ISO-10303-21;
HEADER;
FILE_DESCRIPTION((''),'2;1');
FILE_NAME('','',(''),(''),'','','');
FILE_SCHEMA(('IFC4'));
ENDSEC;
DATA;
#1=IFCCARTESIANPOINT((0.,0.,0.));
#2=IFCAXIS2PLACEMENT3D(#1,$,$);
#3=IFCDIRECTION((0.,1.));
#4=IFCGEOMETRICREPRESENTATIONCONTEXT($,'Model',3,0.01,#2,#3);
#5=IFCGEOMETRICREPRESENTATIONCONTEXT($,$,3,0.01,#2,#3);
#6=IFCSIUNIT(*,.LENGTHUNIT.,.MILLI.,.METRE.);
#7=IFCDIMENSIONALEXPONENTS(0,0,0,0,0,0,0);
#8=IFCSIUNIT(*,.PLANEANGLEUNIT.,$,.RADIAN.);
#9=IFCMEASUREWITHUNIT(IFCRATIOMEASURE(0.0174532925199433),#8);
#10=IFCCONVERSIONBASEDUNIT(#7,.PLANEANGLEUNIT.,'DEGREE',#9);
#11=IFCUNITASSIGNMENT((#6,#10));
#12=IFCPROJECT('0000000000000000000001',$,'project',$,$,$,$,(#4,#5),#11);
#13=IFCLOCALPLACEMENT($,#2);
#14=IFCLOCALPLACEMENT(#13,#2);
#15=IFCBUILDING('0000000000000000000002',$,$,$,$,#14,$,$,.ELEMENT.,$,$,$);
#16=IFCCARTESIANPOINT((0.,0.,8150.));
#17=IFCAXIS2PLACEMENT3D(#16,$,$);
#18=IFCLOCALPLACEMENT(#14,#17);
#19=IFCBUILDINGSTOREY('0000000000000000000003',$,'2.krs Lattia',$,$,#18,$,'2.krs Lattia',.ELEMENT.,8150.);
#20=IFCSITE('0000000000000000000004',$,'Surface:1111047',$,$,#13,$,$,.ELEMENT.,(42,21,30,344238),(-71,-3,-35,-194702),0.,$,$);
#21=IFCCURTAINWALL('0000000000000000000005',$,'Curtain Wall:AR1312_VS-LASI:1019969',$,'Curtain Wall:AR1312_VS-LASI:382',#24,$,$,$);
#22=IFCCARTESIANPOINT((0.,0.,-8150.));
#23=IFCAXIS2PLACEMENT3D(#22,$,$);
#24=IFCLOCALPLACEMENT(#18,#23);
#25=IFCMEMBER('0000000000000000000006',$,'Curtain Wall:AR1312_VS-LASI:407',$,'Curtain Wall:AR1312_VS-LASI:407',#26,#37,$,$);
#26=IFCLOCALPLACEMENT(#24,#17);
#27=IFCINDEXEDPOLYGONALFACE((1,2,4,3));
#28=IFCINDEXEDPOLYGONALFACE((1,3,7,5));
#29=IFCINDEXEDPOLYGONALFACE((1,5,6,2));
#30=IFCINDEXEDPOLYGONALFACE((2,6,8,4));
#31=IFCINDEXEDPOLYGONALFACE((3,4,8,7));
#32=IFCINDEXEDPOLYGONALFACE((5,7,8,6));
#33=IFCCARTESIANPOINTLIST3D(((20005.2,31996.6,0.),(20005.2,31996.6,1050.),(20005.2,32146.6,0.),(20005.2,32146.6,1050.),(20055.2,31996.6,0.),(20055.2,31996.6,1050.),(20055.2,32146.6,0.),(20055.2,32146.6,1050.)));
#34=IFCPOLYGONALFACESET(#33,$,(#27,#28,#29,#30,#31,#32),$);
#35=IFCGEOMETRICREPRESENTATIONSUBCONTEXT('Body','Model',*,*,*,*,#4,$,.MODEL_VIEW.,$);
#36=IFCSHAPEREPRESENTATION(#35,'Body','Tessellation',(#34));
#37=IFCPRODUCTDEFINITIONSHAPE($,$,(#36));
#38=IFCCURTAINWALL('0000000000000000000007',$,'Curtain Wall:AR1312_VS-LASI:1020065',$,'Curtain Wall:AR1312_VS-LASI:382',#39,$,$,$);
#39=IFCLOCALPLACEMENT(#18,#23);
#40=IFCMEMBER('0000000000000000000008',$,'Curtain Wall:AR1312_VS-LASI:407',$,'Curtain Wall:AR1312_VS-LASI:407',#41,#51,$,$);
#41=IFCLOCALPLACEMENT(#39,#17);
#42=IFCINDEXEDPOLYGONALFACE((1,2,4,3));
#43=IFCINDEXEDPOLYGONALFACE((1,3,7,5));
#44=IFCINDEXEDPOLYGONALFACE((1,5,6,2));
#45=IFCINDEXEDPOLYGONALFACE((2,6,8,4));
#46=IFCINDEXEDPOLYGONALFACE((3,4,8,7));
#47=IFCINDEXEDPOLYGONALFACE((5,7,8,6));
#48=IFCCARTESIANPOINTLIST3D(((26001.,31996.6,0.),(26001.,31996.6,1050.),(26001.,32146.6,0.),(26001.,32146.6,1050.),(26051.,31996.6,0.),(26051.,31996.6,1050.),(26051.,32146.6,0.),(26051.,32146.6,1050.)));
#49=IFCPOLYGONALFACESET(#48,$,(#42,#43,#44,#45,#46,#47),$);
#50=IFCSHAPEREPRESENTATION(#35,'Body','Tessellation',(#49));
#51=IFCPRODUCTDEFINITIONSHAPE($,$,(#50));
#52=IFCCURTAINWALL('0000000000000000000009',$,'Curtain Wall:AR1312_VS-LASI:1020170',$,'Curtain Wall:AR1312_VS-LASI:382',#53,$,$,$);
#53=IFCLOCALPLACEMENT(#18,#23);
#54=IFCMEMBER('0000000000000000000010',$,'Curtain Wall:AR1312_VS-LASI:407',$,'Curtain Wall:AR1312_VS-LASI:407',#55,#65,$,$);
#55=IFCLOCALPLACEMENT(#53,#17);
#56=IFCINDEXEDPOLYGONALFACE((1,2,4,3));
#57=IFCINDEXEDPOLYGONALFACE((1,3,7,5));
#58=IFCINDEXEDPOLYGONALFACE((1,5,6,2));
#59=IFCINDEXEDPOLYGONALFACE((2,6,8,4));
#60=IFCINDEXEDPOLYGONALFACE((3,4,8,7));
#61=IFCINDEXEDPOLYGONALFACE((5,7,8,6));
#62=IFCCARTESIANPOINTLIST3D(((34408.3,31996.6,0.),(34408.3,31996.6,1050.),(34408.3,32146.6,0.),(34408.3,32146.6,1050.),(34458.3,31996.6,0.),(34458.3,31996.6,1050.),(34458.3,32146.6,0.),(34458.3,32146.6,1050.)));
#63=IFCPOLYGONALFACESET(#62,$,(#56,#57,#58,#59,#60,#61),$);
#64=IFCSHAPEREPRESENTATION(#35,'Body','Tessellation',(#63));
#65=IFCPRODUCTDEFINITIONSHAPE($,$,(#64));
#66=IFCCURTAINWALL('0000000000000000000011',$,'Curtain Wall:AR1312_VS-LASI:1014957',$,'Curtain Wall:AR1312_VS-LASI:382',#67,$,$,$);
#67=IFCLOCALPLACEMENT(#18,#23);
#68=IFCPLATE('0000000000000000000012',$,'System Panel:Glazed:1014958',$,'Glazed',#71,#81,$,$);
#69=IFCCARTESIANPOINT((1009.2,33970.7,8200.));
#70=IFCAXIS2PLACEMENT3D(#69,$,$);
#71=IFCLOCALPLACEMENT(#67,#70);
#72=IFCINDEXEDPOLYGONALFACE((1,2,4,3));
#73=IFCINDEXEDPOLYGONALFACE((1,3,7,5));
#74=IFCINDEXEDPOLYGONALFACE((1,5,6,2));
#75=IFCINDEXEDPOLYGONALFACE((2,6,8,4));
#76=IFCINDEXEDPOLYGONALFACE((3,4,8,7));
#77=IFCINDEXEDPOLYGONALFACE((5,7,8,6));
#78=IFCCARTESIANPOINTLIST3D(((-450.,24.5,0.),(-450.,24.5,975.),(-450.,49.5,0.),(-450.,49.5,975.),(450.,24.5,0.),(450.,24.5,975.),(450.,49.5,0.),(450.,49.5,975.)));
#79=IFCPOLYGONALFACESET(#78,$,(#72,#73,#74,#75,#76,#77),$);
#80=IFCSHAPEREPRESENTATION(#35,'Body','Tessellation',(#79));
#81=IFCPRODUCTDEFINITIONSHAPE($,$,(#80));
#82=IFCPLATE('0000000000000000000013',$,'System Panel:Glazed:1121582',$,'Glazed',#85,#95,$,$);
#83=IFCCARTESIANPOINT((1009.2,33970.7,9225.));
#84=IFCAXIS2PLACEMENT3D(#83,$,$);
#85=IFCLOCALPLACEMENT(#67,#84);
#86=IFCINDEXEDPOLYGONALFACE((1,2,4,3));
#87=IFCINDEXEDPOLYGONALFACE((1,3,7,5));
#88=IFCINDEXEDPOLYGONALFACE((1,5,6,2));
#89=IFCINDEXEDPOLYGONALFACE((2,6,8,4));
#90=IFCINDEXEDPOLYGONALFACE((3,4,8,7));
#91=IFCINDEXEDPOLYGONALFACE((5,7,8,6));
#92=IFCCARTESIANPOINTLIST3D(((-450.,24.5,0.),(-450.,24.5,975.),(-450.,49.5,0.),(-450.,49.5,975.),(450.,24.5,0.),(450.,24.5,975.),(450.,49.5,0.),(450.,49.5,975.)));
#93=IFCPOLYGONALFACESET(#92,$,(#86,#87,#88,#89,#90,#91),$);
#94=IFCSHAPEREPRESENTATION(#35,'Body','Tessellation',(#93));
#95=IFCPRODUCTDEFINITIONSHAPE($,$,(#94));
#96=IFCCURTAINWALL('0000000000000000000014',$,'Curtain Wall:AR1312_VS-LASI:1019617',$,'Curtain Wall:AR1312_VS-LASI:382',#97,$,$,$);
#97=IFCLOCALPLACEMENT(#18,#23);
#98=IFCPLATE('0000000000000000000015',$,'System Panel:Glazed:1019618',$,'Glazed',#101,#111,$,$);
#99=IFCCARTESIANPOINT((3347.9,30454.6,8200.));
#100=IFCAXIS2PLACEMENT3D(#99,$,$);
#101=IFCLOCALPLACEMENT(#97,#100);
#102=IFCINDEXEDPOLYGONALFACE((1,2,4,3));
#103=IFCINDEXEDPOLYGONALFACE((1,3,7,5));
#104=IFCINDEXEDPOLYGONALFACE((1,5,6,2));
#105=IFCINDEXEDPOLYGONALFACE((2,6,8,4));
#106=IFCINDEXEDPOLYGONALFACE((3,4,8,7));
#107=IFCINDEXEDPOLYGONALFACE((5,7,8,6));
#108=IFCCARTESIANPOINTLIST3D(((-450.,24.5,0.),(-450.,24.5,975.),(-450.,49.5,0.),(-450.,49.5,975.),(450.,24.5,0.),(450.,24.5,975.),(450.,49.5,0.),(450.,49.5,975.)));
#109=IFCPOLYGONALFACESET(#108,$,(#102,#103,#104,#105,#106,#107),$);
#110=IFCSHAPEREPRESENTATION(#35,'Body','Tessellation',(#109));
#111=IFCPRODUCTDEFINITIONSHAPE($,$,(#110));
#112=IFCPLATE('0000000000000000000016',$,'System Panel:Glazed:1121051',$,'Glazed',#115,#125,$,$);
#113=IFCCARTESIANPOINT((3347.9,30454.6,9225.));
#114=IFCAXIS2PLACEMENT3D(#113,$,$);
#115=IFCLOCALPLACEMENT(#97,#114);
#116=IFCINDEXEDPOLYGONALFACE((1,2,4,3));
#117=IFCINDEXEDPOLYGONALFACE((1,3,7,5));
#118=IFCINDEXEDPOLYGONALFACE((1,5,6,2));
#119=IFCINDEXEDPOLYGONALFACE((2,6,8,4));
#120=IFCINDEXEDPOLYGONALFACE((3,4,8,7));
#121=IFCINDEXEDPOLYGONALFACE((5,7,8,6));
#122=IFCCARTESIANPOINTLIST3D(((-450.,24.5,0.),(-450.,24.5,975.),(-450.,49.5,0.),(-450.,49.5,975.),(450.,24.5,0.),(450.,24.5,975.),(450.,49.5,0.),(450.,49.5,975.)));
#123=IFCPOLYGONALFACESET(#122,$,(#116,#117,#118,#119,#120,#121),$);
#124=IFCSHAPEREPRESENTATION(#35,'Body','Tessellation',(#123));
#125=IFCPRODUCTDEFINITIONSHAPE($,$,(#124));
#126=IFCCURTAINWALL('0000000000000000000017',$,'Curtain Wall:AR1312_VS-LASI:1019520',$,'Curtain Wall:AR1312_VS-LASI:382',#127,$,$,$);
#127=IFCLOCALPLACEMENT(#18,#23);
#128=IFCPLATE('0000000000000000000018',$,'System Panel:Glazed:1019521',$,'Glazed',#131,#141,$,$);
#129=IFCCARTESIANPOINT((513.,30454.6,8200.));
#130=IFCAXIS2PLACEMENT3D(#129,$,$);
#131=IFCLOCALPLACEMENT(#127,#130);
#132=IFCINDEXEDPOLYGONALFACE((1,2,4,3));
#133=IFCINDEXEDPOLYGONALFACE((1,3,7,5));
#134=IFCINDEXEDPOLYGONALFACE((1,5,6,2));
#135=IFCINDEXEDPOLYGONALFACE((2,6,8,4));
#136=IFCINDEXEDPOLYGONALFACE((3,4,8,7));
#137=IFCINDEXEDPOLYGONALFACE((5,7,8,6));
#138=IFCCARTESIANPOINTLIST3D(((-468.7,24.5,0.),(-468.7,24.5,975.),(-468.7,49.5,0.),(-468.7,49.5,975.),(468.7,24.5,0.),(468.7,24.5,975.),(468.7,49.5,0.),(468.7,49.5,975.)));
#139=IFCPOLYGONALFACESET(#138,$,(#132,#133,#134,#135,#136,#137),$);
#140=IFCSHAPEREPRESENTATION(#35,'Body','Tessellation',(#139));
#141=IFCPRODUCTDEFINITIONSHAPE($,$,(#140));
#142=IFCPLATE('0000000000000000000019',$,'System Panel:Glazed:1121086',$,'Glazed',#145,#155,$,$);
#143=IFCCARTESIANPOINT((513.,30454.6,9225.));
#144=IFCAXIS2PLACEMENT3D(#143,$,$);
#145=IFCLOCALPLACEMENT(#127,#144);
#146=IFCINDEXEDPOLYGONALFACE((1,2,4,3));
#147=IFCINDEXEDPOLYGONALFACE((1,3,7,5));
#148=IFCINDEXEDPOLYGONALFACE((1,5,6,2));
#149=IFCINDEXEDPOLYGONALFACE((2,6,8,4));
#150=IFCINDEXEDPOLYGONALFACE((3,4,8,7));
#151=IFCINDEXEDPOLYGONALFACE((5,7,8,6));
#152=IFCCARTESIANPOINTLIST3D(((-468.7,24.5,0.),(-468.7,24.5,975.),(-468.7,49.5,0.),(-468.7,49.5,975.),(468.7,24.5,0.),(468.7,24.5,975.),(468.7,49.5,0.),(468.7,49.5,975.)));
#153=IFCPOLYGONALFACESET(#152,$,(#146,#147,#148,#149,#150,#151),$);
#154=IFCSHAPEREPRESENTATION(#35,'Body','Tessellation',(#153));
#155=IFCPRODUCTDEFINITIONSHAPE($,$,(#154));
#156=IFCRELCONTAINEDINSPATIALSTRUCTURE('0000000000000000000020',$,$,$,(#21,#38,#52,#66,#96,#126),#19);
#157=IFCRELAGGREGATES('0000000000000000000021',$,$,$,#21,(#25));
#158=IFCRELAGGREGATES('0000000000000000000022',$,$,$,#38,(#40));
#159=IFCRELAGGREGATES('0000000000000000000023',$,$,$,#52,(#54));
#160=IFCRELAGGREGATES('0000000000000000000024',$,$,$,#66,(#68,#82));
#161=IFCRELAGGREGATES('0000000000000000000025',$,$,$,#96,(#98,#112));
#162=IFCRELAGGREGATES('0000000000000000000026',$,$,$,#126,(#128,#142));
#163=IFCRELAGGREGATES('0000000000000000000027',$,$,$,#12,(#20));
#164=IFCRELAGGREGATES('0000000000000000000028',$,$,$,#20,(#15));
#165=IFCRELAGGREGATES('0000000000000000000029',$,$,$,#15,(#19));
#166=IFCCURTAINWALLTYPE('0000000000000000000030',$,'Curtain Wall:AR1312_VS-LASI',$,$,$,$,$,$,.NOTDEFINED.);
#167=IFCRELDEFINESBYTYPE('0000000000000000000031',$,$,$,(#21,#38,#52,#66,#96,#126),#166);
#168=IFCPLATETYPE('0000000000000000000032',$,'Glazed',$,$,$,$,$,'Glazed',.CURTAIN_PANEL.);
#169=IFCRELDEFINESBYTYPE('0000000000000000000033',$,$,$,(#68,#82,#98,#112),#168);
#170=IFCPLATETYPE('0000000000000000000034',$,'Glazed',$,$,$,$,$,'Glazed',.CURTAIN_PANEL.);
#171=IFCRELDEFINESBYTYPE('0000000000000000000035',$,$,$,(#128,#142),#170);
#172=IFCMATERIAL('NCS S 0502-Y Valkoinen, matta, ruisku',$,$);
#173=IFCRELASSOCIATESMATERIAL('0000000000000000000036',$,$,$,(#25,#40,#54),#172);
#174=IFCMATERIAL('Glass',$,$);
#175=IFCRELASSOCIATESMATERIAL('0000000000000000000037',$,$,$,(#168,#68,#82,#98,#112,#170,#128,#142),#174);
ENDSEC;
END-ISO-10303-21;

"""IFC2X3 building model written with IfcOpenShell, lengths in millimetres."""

from ifc_helpers import new_model, entity, si_unit, converted_unit, direction, frame, frame_2d, origin, origin_2d_with_axis, place, context, subcontext, project, spatial, rectangle, extrude, source, transform, mapped, material, type_object, type_shapes, element, aggregate, save


model = new_model("IFC2X3")

# Units and contexts
model_context = context("Model", 3, precision=0.01, world=origin(), true_north=direction((0.0, 1.0)))
context_of_model = context(None, 3, precision=0.01, world=origin(), true_north=direction((0.0, 1.0)))
body_context = subcontext(model_context, "Body", "Model", "MODEL_VIEW")
ifc_project = project(units=[si_unit("LENGTHUNIT", "METRE", prefix="MILLI"), converted_unit("PLANEANGLEUNIT", "DEGREE", entity("IfcRatioMeasure", 0.0174532925199433), si_unit("PLANEANGLEUNIT", "RADIAN"), dimensions=[0, 0, 0, 0, 0, 0, 0])], contexts=[model_context, context_of_model])

# Site, building, storey
site_placement = place(None, origin())
site = spatial("IfcSite", under=ifc_project, at=site_placement, Name="Surface:1111047", CompositionType="ELEMENT", RefLatitude=(42, 21, 30, 344238), RefLongitude=(-71, -3, -35, -194702), RefElevation=0.0)
building_placement = place(site_placement, origin())
building = spatial("IfcBuilding", under=site, at=building_placement, CompositionType="ELEMENT")
storey_placement = place(building_placement, frame((0.0, 0.0, 8150.0)))
storey = spatial("IfcBuildingStorey", under=building, at=storey_placement, Name="2.krs Lattia", LongName="2.krs Lattia", CompositionType="ELEMENT", Elevation=8150.0)

# Curtain walls, members
curtain_wall_type = type_object("IfcCurtainWallType", Name="Curtain Wall:AR1312_VS-LASI", PredefinedType="NOTDEFINED")
ifc_material_1 = material(Name="NCS S 0502-Y Valkoinen, matta, ruisku")
curtain_wall_1_placement = place(storey_placement, frame((0.0, 0.0, -8150.0)))
curtain_wall_1 = element("IfcCurtainWall", 1, at=curtain_wall_1_placement, inside=storey, type_object=curtain_wall_type, Name="Curtain Wall:AR1312_VS-LASI:1019969", ObjectType="Curtain Wall:AR1312_VS-LASI:382")
member_1_placement = place(curtain_wall_1_placement, frame((0.0, 0.0, 8150.0)))
member_1 = element("IfcMember", 2, at=member_1_placement, material=ifc_material_1, Name="Curtain Wall:AR1312_VS-LASI:407", ObjectType="Curtain Wall:AR1312_VS-LASI:407", context=body_context, shape_type="SweptSolid", body=[
    extrude(rectangle(XDim=50.0, YDim=150.0, at=frame_2d((0.0, 0.0), x_axis=(1.0, 0.0))), frame((20030.2, 32071.6, 0.0), z_axis=(0.0, 0.0, 1.0), x_axis=(-1.0, 0.0, 0.0)), (0.0, 0.0, 1.0), 1050.0),
])
aggregate(curtain_wall_1, [member_1])
curtain_wall_2_placement = place(storey_placement, frame((0.0, 0.0, -8150.0)))
curtain_wall_2 = element("IfcCurtainWall", 3, at=curtain_wall_2_placement, inside=storey, type_object=curtain_wall_type, Name="Curtain Wall:AR1312_VS-LASI:1020065", ObjectType="Curtain Wall:AR1312_VS-LASI:382")
member_2_placement = place(curtain_wall_2_placement, frame((0.0, 0.0, 8150.0)))
member_2 = element("IfcMember", 4, at=member_2_placement, material=ifc_material_1, Name="Curtain Wall:AR1312_VS-LASI:407", ObjectType="Curtain Wall:AR1312_VS-LASI:407", context=body_context, shape_type="SweptSolid", body=[
    extrude(rectangle(XDim=50.0, YDim=150.0, at=frame_2d((0.0, 0.0), x_axis=(1.0, 0.0))), frame((26026.0, 32071.6, 0.0), z_axis=(0.0, 0.0, 1.0), x_axis=(-1.0, 0.0, 0.0)), (0.0, 0.0, 1.0), 1050.0),
])
aggregate(curtain_wall_2, [member_2])
curtain_wall_3_placement = place(storey_placement, frame((0.0, 0.0, -8150.0)))
curtain_wall_3 = element("IfcCurtainWall", 5, at=curtain_wall_3_placement, inside=storey, type_object=curtain_wall_type, Name="Curtain Wall:AR1312_VS-LASI:1020170", ObjectType="Curtain Wall:AR1312_VS-LASI:382")
member_3_placement = place(curtain_wall_3_placement, frame((0.0, 0.0, 8150.0)))
member_3 = element("IfcMember", 6, at=member_3_placement, material=ifc_material_1, Name="Curtain Wall:AR1312_VS-LASI:407", ObjectType="Curtain Wall:AR1312_VS-LASI:407", context=body_context, shape_type="SweptSolid", body=[
    extrude(rectangle(XDim=50.0, YDim=150.0, at=frame_2d((0.0, 0.0), x_axis=(1.0, 0.0))), frame((34433.3, 32071.6, 0.0), z_axis=(0.0, 0.0, 1.0), x_axis=(-1.0, 0.0, 0.0)), (0.0, 0.0, 1.0), 1050.0),
])
aggregate(curtain_wall_3, [member_3])

# Curtain walls, plates
curtain_wall_4_placement = place(storey_placement, frame((0.0, 0.0, -8150.0)))
curtain_wall_4 = element("IfcCurtainWall", 7, at=curtain_wall_4_placement, inside=storey, type_object=curtain_wall_type, Name="Curtain Wall:AR1312_VS-LASI:1014957", ObjectType="Curtain Wall:AR1312_VS-LASI:382")
ifc_material_2 = material(Name="Glass")
plate_type_1 = type_object("IfcPlateType", Name="Glazed", ElementType="Glazed", PredefinedType="CURTAIN_PANEL", material=ifc_material_2)
shared_shape_1 = source(origin(), body_context, "Body", "SweptSolid", [
    extrude(rectangle(XDim=25.0, YDim=900.0, at=origin_2d_with_axis()), frame((0.0, 37.0, 0.0), z_axis=(0.0, 0.0, 1.0), x_axis=(0.0, 1.0, 0.0)), (0.0, 0.0, 1.0), 975.0),
])
type_shapes(plate_type_1, [shared_shape_1])
plate_1_placement = place(curtain_wall_4_placement, frame((1009.2, 33970.7, 8200.0)))
plate_1 = element("IfcPlate", 8, at=plate_1_placement, type_object=plate_type_1, material=ifc_material_2, Name="System Panel:Glazed:1014958", ObjectType="Glazed", context=body_context, shape_type="MappedRepresentation", body=[
    mapped(shared_shape_1, transform((0.0, 0.0, 0.0), scale=1.0)),
])
plate_2_placement = place(curtain_wall_4_placement, frame((1009.2, 33970.7, 9225.0)))
plate_2 = element("IfcPlate", 9, at=plate_2_placement, type_object=plate_type_1, material=ifc_material_2, Name="System Panel:Glazed:1121582", ObjectType="Glazed", context=body_context, shape_type="MappedRepresentation", body=[
    mapped(shared_shape_1, transform((0.0, 0.0, 0.0), scale=1.0)),
])
aggregate(curtain_wall_4, [plate_1, plate_2])
curtain_wall_5_placement = place(storey_placement, frame((0.0, 0.0, -8150.0)))
curtain_wall_5 = element("IfcCurtainWall", 10, at=curtain_wall_5_placement, inside=storey, type_object=curtain_wall_type, Name="Curtain Wall:AR1312_VS-LASI:1019617", ObjectType="Curtain Wall:AR1312_VS-LASI:382")
plate_3_placement = place(curtain_wall_5_placement, frame((3347.9, 30454.6, 8200.0)))
plate_3 = element("IfcPlate", 11, at=plate_3_placement, type_object=plate_type_1, material=ifc_material_2, Name="System Panel:Glazed:1019618", ObjectType="Glazed", context=body_context, shape_type="MappedRepresentation", body=[
    mapped(shared_shape_1, transform((0.0, 0.0, 0.0), scale=1.0)),
])
plate_4_placement = place(curtain_wall_5_placement, frame((3347.9, 30454.6, 9225.0)))
plate_4 = element("IfcPlate", 12, at=plate_4_placement, type_object=plate_type_1, material=ifc_material_2, Name="System Panel:Glazed:1121051", ObjectType="Glazed", context=body_context, shape_type="MappedRepresentation", body=[
    mapped(shared_shape_1, transform((0.0, 0.0, 0.0), scale=1.0)),
])
aggregate(curtain_wall_5, [plate_3, plate_4])
curtain_wall_6_placement = place(storey_placement, frame((0.0, 0.0, -8150.0)))
curtain_wall_6 = element("IfcCurtainWall", 13, at=curtain_wall_6_placement, inside=storey, type_object=curtain_wall_type, Name="Curtain Wall:AR1312_VS-LASI:1019520", ObjectType="Curtain Wall:AR1312_VS-LASI:382")
plate_type_2 = type_object("IfcPlateType", Name="Glazed", ElementType="Glazed", PredefinedType="CURTAIN_PANEL", material=ifc_material_2)
shared_shape_2 = source(origin(), body_context, "Body", "SweptSolid", [
    extrude(rectangle(XDim=25.0, YDim=937.4, at=origin_2d_with_axis()), frame((0.0, 37.0, 0.0), z_axis=(0.0, 0.0, 1.0), x_axis=(0.0, 1.0, 0.0)), (0.0, 0.0, 1.0), 975.0),
])
type_shapes(plate_type_2, [shared_shape_2])
plate_5_placement = place(curtain_wall_6_placement, frame((513.0, 30454.6, 8200.0)))
plate_5 = element("IfcPlate", 14, at=plate_5_placement, type_object=plate_type_2, material=ifc_material_2, Name="System Panel:Glazed:1019521", ObjectType="Glazed", context=body_context, shape_type="MappedRepresentation", body=[
    mapped(shared_shape_2, transform((0.0, 0.0, 0.0), scale=1.0)),
])
plate_6_placement = place(curtain_wall_6_placement, frame((513.0, 30454.6, 9225.0)))
plate_6 = element("IfcPlate", 15, at=plate_6_placement, type_object=plate_type_2, material=ifc_material_2, Name="System Panel:Glazed:1121086", ObjectType="Glazed", context=body_context, shape_type="MappedRepresentation", body=[
    mapped(shared_shape_2, transform((0.0, 0.0, 0.0), scale=1.0)),
])
aggregate(curtain_wall_6, [plate_5, plate_6])

save(model, "model.ifc")
